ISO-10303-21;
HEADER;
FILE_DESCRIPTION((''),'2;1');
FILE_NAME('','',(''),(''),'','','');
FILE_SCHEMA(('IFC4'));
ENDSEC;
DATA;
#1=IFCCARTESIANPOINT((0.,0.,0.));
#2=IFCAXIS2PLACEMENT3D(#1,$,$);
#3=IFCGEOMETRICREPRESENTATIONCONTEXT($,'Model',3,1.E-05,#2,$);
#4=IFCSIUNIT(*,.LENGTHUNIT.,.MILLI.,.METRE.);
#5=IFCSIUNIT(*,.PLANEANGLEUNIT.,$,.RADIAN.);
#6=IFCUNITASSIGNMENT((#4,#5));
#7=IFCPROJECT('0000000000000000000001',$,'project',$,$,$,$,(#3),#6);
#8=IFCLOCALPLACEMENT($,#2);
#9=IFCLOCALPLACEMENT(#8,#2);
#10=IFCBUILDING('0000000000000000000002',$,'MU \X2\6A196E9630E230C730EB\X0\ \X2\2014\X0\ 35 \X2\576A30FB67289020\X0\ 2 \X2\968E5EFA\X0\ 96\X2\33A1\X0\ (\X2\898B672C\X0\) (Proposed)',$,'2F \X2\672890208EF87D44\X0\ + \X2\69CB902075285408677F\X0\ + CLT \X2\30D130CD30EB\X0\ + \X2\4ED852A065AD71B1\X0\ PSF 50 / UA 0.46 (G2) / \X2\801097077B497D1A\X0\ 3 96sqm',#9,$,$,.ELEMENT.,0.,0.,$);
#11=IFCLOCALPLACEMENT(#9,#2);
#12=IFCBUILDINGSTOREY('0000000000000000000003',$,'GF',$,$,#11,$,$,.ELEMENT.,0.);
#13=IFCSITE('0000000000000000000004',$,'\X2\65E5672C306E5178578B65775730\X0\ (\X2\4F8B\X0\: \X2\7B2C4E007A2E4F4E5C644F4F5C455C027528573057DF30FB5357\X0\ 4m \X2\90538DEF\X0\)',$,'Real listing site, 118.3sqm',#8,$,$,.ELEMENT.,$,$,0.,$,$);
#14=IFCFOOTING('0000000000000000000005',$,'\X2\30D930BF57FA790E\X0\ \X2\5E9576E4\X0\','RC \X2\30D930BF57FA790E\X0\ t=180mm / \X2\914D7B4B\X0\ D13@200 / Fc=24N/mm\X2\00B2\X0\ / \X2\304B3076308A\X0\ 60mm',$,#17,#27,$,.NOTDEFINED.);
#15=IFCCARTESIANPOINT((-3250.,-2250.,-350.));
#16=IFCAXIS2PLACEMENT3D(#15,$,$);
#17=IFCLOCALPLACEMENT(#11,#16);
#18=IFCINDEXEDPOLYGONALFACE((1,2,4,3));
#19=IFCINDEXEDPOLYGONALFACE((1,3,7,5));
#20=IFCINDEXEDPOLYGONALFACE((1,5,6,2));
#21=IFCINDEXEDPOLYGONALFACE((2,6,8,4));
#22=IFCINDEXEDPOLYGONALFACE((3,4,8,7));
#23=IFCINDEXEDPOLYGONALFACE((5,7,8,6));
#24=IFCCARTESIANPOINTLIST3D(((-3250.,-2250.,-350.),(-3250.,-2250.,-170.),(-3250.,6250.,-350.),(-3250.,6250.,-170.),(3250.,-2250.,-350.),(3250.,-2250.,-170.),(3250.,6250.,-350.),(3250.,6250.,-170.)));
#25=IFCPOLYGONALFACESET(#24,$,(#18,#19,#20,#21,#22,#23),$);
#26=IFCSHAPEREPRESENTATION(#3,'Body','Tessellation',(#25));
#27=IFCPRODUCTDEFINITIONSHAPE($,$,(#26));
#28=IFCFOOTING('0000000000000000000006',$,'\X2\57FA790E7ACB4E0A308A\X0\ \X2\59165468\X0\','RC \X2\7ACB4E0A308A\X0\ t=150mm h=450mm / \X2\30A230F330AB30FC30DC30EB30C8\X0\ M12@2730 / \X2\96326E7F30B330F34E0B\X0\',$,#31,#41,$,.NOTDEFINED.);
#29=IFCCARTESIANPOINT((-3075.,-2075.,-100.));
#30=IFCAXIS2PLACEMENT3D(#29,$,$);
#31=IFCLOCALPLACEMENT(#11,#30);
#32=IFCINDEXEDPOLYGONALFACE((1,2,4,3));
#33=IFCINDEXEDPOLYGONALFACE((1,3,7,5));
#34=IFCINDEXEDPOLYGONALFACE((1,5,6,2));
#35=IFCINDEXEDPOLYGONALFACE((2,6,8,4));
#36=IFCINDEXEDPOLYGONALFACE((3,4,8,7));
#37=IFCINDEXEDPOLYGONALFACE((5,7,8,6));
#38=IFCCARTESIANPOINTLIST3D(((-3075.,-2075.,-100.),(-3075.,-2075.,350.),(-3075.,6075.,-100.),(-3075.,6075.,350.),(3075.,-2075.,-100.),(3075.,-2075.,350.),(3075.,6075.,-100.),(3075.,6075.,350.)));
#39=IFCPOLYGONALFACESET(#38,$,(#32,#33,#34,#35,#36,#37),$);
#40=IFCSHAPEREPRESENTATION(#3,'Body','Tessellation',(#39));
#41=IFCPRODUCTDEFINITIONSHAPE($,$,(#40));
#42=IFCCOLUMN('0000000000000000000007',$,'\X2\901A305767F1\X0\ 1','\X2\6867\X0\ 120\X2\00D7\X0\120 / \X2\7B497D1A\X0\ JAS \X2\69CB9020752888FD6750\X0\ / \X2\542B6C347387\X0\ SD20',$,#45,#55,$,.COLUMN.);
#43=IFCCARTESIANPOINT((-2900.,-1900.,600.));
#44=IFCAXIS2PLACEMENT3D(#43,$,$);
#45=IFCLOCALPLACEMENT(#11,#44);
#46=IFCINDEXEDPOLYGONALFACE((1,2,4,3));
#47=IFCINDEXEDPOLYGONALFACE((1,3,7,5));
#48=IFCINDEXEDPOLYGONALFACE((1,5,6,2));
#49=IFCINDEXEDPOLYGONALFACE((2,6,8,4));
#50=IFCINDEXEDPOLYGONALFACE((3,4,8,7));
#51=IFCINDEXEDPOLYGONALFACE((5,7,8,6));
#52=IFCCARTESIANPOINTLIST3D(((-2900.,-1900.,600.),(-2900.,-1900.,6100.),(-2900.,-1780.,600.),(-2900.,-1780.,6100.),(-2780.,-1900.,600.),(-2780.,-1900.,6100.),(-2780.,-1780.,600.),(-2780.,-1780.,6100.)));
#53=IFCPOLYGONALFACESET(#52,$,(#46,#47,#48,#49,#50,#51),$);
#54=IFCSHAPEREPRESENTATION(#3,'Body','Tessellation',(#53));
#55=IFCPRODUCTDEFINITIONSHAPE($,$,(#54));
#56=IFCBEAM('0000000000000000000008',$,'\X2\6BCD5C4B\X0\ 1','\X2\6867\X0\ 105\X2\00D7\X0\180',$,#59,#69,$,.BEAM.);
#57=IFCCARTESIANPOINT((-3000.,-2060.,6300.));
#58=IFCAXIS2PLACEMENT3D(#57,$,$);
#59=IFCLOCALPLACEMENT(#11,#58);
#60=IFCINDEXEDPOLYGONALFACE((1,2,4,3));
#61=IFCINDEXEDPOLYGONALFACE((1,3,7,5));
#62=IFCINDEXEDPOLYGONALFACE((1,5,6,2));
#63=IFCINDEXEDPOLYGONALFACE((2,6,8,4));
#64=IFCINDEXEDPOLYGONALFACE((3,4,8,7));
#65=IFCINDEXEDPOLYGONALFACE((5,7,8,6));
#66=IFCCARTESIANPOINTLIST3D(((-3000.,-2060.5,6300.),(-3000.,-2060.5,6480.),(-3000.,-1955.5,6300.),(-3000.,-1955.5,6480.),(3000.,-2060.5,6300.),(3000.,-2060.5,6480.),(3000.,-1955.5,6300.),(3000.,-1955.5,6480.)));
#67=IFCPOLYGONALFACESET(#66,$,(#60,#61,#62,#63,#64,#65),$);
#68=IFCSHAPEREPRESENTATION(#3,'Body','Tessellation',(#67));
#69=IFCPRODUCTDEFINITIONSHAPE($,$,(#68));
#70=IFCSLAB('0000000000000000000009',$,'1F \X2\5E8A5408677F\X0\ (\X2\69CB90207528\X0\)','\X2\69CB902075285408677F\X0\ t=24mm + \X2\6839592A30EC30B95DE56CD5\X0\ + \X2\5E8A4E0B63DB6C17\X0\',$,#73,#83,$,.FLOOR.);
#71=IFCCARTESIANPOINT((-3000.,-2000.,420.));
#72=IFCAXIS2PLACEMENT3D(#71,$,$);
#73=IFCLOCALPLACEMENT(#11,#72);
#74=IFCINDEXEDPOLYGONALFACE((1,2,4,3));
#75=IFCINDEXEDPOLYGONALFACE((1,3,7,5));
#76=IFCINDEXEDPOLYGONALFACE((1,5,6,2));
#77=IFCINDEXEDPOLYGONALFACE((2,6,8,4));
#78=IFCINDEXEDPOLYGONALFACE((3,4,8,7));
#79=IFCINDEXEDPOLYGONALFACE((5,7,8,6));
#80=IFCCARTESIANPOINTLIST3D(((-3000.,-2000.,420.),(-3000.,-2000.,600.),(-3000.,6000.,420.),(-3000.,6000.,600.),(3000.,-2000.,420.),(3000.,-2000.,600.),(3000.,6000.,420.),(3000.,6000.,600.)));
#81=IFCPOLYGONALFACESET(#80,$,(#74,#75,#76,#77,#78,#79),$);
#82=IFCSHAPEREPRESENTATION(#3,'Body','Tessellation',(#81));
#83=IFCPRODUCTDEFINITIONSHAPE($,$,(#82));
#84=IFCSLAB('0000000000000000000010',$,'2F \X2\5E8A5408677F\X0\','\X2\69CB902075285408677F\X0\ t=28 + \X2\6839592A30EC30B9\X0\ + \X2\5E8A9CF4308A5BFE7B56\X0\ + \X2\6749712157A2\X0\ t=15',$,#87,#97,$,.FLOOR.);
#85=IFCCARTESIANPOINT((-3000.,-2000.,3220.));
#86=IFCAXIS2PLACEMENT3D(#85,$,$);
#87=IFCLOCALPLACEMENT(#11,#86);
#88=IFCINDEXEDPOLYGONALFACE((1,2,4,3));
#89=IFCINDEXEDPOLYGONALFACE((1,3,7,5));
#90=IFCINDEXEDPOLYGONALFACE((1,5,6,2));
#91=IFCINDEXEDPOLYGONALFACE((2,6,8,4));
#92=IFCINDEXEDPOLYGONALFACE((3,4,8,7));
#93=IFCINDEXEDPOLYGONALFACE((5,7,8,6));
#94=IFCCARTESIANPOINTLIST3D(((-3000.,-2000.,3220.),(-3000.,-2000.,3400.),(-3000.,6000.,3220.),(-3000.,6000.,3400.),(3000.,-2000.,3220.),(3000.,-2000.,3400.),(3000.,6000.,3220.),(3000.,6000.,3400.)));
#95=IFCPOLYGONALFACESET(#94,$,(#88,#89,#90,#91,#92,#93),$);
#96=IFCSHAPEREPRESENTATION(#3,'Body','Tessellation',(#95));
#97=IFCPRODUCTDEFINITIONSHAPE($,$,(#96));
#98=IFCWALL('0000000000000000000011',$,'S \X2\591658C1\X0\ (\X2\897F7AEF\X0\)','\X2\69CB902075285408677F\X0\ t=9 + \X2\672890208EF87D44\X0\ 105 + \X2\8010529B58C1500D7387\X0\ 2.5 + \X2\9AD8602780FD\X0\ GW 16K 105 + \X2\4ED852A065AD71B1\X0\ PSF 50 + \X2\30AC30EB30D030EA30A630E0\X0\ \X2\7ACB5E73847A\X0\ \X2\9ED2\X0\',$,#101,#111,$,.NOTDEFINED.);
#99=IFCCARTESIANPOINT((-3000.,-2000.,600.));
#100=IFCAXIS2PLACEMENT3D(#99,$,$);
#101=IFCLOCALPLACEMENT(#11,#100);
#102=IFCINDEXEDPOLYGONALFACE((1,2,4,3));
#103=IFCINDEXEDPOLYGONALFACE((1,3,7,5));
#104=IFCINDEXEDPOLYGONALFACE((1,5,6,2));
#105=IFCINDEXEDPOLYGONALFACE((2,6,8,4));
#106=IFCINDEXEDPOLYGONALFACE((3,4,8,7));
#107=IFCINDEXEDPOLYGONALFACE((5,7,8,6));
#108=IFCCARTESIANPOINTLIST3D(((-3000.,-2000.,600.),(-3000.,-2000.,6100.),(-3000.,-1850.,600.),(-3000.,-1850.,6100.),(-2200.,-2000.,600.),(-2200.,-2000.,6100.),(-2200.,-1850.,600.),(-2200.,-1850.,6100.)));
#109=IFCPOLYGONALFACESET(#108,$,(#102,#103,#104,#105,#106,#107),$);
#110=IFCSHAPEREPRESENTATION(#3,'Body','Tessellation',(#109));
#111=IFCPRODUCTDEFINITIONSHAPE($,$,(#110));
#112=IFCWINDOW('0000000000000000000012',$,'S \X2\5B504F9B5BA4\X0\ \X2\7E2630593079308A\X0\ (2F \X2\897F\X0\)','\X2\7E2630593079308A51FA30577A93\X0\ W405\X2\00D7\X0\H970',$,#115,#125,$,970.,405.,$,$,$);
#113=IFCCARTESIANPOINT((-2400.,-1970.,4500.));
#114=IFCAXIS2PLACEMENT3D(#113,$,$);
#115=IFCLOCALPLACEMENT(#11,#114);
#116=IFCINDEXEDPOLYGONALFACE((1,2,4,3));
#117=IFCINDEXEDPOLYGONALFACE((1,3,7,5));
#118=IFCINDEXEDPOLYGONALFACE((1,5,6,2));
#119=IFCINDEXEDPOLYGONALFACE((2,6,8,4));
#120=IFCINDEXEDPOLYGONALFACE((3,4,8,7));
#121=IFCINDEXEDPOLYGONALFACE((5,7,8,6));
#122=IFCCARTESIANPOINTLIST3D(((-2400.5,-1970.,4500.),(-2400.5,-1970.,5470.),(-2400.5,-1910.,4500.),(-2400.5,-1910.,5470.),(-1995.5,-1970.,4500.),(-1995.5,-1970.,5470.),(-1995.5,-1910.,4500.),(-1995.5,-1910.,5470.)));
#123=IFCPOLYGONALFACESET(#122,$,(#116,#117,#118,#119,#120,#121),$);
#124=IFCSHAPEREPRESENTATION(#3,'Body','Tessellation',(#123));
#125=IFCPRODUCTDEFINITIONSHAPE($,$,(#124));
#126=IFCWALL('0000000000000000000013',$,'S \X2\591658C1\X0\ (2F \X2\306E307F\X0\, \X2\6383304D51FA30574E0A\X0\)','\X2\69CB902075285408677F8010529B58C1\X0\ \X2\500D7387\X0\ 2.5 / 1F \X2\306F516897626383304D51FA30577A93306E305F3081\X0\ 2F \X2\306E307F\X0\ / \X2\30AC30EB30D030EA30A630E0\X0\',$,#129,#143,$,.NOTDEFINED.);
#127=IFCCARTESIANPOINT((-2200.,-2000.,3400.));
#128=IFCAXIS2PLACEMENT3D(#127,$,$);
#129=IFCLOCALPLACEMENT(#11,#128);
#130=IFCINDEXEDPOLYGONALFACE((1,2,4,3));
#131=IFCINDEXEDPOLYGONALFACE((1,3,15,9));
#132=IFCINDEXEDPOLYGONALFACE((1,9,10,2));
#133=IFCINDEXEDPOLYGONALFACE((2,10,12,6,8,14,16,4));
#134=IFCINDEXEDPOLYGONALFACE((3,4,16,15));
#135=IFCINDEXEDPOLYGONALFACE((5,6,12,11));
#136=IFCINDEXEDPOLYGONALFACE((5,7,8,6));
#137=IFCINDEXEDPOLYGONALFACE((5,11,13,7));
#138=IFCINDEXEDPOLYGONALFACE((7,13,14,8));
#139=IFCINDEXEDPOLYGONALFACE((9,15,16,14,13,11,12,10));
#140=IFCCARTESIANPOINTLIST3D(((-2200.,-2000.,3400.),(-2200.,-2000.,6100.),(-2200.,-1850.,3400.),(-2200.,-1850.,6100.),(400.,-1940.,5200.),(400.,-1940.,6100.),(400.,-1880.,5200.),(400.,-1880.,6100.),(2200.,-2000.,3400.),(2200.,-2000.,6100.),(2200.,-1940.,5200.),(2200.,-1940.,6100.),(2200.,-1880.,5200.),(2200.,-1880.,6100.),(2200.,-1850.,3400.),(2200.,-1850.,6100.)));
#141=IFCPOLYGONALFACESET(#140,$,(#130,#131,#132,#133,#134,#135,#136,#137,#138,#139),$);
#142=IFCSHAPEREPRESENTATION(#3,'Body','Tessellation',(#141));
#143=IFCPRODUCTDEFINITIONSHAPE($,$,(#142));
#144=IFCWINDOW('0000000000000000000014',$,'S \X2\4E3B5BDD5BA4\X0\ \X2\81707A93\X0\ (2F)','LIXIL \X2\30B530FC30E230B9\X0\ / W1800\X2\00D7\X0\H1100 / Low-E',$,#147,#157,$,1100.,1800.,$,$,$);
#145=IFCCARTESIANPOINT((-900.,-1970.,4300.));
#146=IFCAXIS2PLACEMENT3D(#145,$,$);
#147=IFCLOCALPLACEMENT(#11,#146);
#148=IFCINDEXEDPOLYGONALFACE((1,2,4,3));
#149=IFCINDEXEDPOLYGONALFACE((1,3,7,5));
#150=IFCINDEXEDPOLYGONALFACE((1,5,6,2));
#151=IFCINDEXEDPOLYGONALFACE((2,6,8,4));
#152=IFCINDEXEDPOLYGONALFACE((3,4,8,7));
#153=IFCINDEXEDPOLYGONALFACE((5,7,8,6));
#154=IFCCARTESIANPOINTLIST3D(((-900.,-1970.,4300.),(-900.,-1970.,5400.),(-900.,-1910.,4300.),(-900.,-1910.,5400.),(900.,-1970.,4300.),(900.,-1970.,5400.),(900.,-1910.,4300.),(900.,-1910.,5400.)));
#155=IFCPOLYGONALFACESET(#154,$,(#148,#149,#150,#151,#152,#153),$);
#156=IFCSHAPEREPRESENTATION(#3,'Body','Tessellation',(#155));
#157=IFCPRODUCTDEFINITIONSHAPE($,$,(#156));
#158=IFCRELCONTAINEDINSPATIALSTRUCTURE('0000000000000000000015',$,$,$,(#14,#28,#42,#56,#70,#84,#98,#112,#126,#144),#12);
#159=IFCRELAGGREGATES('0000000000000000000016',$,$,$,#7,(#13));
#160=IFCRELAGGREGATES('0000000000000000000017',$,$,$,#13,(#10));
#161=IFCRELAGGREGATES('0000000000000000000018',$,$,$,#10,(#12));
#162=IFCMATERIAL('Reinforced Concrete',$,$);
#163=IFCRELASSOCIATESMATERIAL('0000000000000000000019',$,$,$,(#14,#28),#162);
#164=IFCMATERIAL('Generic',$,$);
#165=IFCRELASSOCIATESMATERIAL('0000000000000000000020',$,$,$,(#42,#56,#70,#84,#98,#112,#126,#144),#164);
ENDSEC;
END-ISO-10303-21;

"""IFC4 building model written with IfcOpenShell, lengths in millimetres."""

from ifc_helpers import new_model, si_unit, frame, frame_2d, origin, place, context, project, spatial, rectangle, extrude, material, element, fill, save


model = new_model("IFC4")

# Units and contexts
model_context = context("Model", 3, precision=1e-05, world=origin())
ifc_project = project(units=[si_unit("LENGTHUNIT", "METRE", prefix="MILLI"), si_unit("PLANEANGLEUNIT", "RADIAN")], contexts=[model_context])

# Site, building, storey
site_placement = place(None, origin())
site = spatial("IfcSite", under=ifc_project, at=site_placement, Name="日本の典型敷地 (例: 第一種低層住居専用地域・南 4m 道路)", ObjectType="Real listing site, 118.3sqm", CompositionType="ELEMENT", RefElevation=0.0)
building_placement = place(site_placement, origin())
building = spatial("IfcBuilding", under=site, at=building_placement, Name="MU 標準モデル — 35 坪・木造 2 階建 96㎡ (見本) (Proposed)", ObjectType="2F 木造軸組 + 構造用合板 + CLT パネル + 付加断熱 PSF 50 / UA 0.46 (G2) / 耐震等級 3 96sqm", CompositionType="ELEMENT", ElevationOfRefHeight=0.0, ElevationOfTerrain=0.0)
storey_placement = place(building_placement, origin())
storey = spatial("IfcBuildingStorey", under=building, at=storey_placement, Name="GF", CompositionType="ELEMENT", Elevation=0.0)

# Footings
ifc_material_1 = material(Name="Reinforced Concrete")
footing_1_placement = place(storey_placement, frame((-3250.0, -2250.0, -350.0)))
element("IfcFooting", 1, at=footing_1_placement, inside=storey, material=ifc_material_1, Name="ベタ基礎 底盤", Description="RC ベタ基礎 t=180mm / 配筋 D13@200 / Fc=24N/mm² / かぶり 60mm", PredefinedType="NOTDEFINED", context=model_context, shape_type="SweptSolid", body=[
    extrude(rectangle(XDim=6500.0, YDim=8500.0, at=frame_2d((3250.0, 4250.0))), frame((-3250.0, -2250.0, -350.0)), (0.0, 0.0, 1.0), 180.0),
])
footing_2_placement = place(storey_placement, frame((-3075.0, -2075.0, -100.0)))
element("IfcFooting", 2, at=footing_2_placement, inside=storey, material=ifc_material_1, Name="基礎立上り 外周", Description="RC 立上り t=150mm h=450mm / アンカーボルト M12@2730 / 防湿コン下", PredefinedType="NOTDEFINED", context=model_context, shape_type="SweptSolid", body=[
    extrude(rectangle(XDim=6150.0, YDim=8150.0, at=frame_2d((3075.0, 4075.0))), frame((-3075.0, -2075.0, -100.0)), (0.0, 0.0, 1.0), 450.0),
])

# Column
ifc_material_2 = material(Name="Generic")
column_placement = place(storey_placement, frame((-2900.0, -1900.0, 600.0)))
element("IfcColumn", 3, at=column_placement, inside=storey, material=ifc_material_2, Name="通し柱 1", Description="桧 120×120 / 等級 JAS 構造用製材 / 含水率 SD20", PredefinedType="COLUMN", context=model_context, shape_type="SweptSolid", body=[
    extrude(rectangle(XDim=120.0, YDim=120.0, at=frame_2d((60.0, 60.0))), frame((-2900.0, -1900.0, 600.0)), (0.0, 0.0, 1.0), 5500.0),
])

# Beam
beam_placement = place(storey_placement, frame((-3000.0, -2060.0, 6300.0)))
element("IfcBeam", 4, at=beam_placement, inside=storey, material=ifc_material_2, Name="母屋 1", Description="桧 105×180", PredefinedType="BEAM", context=model_context, shape_type="SweptSolid", body=[
    extrude(rectangle(XDim=6000.0, YDim=105.0, at=frame_2d((3000.0, 52.0))), frame((-3000.0, -2060.0, 6300.0)), (0.0, 0.0, 1.0), 180.0),
])

# Slabs
slab_1_placement = place(storey_placement, frame((-3000.0, -2000.0, 420.0)))
element("IfcSlab", 5, at=slab_1_placement, inside=storey, material=ifc_material_2, Name="1F 床合板 (構造用)", Description="構造用合板 t=24mm + 根太レス工法 + 床下換気", PredefinedType="FLOOR", context=model_context, shape_type="SweptSolid", body=[
    extrude(rectangle(XDim=6000.0, YDim=8000.0, at=frame_2d((3000.0, 4000.0))), frame((-3000.0, -2000.0, 420.0)), (0.0, 0.0, 1.0), 180.0),
])
slab_2_placement = place(storey_placement, frame((-3000.0, -2000.0, 3220.0)))
element("IfcSlab", 6, at=slab_2_placement, inside=storey, material=ifc_material_2, Name="2F 床合板", Description="構造用合板 t=28 + 根太レス + 床鳴り対策 + 杉無垢 t=15", PredefinedType="FLOOR", context=model_context, shape_type="SweptSolid", body=[
    extrude(rectangle(XDim=6000.0, YDim=8000.0, at=frame_2d((3000.0, 4000.0))), frame((-3000.0, -2000.0, 3220.0)), (0.0, 0.0, 1.0), 180.0),
])

# Walls, openings, windows
wall_1_placement = place(storey_placement, frame((-3000.0, -2000.0, 600.0)))
wall_1 = element("IfcWall", 7, at=wall_1_placement, inside=storey, material=ifc_material_2, Name="S 外壁 (西端)", Description="構造用合板 t=9 + 木造軸組 105 + 耐力壁倍率 2.5 + 高性能 GW 16K 105 + 付加断熱 PSF 50 + ガルバリウム 立平葺 黒", PredefinedType="NOTDEFINED", context=model_context, shape_type="SweptSolid", body=[
    extrude(rectangle(XDim=800.0, YDim=150.0, at=frame_2d((400.0, 75.0))), frame((-3000.0, -2000.0, 600.0)), (0.0, 0.0, 1.0), 5500.0),
])
opening_1_placement = place(storey_placement, frame((-2400.0, -1970.0, 4500.0)))
opening_1 = element("IfcOpeningElement", 8, at=opening_1_placement, cuts=wall_1, PredefinedType="NOTDEFINED", context=model_context, shape_type="SweptSolid", body=[
    extrude(rectangle(XDim=405.0, YDim=60.0, at=frame_2d((202.0, 30.0))), frame((-2400.0, -1970.0, 4500.0)), (0.0, 0.0, 1.0), 970.0),
])
window_1_placement = place(storey_placement, frame((-2400.0, -1970.0, 4500.0)))
window_1 = element("IfcWindow", 9, at=window_1_placement, inside=storey, material=ifc_material_2, Name="S 子供室 縦すべり (2F 西)", Description="縦すべり出し窓 W405×H970", OverallHeight=970.0, OverallWidth=405.0, context=model_context, shape_type="SweptSolid", body=[
    extrude(rectangle(XDim=405.0, YDim=60.0, at=frame_2d((202.0, 30.0))), frame((-2400.0, -1970.0, 4500.0)), (0.0, 0.0, 1.0), 970.0),
])
fill(opening_1, window_1)
wall_2_placement = place(storey_placement, frame((-2200.0, -2000.0, 3400.0)))
wall_2 = element("IfcWall", 10, at=wall_2_placement, inside=storey, material=ifc_material_2, Name="S 外壁 (2F のみ, 掃き出し上)", Description="構造用合板耐力壁 倍率 2.5 / 1F は全面掃き出し窓のため 2F のみ / ガルバリウム", PredefinedType="NOTDEFINED", context=model_context, shape_type="SweptSolid", body=[
    extrude(rectangle(XDim=4400.0, YDim=150.0, at=frame_2d((2200.0, 75.0))), frame((-2200.0, -2000.0, 3400.0)), (0.0, 0.0, 1.0), 2700.0),
])
opening_2_placement = place(storey_placement, frame((-900.0, -1970.0, 4300.0)))
opening_2 = element("IfcOpeningElement", 11, at=opening_2_placement, cuts=wall_2, PredefinedType="NOTDEFINED", context=model_context, shape_type="SweptSolid", body=[
    extrude(rectangle(XDim=1800.0, YDim=60.0, at=frame_2d((900.0, 30.0))), frame((-900.0, -1970.0, 4300.0)), (0.0, 0.0, 1.0), 1100.0),
])
window_2_placement = place(storey_placement, frame((-900.0, -1970.0, 4300.0)))
window_2 = element("IfcWindow", 12, at=window_2_placement, inside=storey, material=ifc_material_2, Name="S 主寝室 腰窓 (2F)", Description="LIXIL サーモス / W1800×H1100 / Low-E", OverallHeight=1100.0, OverallWidth=1800.0, context=model_context, shape_type="SweptSolid", body=[
    extrude(rectangle(XDim=1800.0, YDim=60.0, at=frame_2d((900.0, 30.0))), frame((-900.0, -1970.0, 4300.0)), (0.0, 0.0, 1.0), 1100.0),
])
fill(opening_2, window_2)

save(model, "model.ifc")
